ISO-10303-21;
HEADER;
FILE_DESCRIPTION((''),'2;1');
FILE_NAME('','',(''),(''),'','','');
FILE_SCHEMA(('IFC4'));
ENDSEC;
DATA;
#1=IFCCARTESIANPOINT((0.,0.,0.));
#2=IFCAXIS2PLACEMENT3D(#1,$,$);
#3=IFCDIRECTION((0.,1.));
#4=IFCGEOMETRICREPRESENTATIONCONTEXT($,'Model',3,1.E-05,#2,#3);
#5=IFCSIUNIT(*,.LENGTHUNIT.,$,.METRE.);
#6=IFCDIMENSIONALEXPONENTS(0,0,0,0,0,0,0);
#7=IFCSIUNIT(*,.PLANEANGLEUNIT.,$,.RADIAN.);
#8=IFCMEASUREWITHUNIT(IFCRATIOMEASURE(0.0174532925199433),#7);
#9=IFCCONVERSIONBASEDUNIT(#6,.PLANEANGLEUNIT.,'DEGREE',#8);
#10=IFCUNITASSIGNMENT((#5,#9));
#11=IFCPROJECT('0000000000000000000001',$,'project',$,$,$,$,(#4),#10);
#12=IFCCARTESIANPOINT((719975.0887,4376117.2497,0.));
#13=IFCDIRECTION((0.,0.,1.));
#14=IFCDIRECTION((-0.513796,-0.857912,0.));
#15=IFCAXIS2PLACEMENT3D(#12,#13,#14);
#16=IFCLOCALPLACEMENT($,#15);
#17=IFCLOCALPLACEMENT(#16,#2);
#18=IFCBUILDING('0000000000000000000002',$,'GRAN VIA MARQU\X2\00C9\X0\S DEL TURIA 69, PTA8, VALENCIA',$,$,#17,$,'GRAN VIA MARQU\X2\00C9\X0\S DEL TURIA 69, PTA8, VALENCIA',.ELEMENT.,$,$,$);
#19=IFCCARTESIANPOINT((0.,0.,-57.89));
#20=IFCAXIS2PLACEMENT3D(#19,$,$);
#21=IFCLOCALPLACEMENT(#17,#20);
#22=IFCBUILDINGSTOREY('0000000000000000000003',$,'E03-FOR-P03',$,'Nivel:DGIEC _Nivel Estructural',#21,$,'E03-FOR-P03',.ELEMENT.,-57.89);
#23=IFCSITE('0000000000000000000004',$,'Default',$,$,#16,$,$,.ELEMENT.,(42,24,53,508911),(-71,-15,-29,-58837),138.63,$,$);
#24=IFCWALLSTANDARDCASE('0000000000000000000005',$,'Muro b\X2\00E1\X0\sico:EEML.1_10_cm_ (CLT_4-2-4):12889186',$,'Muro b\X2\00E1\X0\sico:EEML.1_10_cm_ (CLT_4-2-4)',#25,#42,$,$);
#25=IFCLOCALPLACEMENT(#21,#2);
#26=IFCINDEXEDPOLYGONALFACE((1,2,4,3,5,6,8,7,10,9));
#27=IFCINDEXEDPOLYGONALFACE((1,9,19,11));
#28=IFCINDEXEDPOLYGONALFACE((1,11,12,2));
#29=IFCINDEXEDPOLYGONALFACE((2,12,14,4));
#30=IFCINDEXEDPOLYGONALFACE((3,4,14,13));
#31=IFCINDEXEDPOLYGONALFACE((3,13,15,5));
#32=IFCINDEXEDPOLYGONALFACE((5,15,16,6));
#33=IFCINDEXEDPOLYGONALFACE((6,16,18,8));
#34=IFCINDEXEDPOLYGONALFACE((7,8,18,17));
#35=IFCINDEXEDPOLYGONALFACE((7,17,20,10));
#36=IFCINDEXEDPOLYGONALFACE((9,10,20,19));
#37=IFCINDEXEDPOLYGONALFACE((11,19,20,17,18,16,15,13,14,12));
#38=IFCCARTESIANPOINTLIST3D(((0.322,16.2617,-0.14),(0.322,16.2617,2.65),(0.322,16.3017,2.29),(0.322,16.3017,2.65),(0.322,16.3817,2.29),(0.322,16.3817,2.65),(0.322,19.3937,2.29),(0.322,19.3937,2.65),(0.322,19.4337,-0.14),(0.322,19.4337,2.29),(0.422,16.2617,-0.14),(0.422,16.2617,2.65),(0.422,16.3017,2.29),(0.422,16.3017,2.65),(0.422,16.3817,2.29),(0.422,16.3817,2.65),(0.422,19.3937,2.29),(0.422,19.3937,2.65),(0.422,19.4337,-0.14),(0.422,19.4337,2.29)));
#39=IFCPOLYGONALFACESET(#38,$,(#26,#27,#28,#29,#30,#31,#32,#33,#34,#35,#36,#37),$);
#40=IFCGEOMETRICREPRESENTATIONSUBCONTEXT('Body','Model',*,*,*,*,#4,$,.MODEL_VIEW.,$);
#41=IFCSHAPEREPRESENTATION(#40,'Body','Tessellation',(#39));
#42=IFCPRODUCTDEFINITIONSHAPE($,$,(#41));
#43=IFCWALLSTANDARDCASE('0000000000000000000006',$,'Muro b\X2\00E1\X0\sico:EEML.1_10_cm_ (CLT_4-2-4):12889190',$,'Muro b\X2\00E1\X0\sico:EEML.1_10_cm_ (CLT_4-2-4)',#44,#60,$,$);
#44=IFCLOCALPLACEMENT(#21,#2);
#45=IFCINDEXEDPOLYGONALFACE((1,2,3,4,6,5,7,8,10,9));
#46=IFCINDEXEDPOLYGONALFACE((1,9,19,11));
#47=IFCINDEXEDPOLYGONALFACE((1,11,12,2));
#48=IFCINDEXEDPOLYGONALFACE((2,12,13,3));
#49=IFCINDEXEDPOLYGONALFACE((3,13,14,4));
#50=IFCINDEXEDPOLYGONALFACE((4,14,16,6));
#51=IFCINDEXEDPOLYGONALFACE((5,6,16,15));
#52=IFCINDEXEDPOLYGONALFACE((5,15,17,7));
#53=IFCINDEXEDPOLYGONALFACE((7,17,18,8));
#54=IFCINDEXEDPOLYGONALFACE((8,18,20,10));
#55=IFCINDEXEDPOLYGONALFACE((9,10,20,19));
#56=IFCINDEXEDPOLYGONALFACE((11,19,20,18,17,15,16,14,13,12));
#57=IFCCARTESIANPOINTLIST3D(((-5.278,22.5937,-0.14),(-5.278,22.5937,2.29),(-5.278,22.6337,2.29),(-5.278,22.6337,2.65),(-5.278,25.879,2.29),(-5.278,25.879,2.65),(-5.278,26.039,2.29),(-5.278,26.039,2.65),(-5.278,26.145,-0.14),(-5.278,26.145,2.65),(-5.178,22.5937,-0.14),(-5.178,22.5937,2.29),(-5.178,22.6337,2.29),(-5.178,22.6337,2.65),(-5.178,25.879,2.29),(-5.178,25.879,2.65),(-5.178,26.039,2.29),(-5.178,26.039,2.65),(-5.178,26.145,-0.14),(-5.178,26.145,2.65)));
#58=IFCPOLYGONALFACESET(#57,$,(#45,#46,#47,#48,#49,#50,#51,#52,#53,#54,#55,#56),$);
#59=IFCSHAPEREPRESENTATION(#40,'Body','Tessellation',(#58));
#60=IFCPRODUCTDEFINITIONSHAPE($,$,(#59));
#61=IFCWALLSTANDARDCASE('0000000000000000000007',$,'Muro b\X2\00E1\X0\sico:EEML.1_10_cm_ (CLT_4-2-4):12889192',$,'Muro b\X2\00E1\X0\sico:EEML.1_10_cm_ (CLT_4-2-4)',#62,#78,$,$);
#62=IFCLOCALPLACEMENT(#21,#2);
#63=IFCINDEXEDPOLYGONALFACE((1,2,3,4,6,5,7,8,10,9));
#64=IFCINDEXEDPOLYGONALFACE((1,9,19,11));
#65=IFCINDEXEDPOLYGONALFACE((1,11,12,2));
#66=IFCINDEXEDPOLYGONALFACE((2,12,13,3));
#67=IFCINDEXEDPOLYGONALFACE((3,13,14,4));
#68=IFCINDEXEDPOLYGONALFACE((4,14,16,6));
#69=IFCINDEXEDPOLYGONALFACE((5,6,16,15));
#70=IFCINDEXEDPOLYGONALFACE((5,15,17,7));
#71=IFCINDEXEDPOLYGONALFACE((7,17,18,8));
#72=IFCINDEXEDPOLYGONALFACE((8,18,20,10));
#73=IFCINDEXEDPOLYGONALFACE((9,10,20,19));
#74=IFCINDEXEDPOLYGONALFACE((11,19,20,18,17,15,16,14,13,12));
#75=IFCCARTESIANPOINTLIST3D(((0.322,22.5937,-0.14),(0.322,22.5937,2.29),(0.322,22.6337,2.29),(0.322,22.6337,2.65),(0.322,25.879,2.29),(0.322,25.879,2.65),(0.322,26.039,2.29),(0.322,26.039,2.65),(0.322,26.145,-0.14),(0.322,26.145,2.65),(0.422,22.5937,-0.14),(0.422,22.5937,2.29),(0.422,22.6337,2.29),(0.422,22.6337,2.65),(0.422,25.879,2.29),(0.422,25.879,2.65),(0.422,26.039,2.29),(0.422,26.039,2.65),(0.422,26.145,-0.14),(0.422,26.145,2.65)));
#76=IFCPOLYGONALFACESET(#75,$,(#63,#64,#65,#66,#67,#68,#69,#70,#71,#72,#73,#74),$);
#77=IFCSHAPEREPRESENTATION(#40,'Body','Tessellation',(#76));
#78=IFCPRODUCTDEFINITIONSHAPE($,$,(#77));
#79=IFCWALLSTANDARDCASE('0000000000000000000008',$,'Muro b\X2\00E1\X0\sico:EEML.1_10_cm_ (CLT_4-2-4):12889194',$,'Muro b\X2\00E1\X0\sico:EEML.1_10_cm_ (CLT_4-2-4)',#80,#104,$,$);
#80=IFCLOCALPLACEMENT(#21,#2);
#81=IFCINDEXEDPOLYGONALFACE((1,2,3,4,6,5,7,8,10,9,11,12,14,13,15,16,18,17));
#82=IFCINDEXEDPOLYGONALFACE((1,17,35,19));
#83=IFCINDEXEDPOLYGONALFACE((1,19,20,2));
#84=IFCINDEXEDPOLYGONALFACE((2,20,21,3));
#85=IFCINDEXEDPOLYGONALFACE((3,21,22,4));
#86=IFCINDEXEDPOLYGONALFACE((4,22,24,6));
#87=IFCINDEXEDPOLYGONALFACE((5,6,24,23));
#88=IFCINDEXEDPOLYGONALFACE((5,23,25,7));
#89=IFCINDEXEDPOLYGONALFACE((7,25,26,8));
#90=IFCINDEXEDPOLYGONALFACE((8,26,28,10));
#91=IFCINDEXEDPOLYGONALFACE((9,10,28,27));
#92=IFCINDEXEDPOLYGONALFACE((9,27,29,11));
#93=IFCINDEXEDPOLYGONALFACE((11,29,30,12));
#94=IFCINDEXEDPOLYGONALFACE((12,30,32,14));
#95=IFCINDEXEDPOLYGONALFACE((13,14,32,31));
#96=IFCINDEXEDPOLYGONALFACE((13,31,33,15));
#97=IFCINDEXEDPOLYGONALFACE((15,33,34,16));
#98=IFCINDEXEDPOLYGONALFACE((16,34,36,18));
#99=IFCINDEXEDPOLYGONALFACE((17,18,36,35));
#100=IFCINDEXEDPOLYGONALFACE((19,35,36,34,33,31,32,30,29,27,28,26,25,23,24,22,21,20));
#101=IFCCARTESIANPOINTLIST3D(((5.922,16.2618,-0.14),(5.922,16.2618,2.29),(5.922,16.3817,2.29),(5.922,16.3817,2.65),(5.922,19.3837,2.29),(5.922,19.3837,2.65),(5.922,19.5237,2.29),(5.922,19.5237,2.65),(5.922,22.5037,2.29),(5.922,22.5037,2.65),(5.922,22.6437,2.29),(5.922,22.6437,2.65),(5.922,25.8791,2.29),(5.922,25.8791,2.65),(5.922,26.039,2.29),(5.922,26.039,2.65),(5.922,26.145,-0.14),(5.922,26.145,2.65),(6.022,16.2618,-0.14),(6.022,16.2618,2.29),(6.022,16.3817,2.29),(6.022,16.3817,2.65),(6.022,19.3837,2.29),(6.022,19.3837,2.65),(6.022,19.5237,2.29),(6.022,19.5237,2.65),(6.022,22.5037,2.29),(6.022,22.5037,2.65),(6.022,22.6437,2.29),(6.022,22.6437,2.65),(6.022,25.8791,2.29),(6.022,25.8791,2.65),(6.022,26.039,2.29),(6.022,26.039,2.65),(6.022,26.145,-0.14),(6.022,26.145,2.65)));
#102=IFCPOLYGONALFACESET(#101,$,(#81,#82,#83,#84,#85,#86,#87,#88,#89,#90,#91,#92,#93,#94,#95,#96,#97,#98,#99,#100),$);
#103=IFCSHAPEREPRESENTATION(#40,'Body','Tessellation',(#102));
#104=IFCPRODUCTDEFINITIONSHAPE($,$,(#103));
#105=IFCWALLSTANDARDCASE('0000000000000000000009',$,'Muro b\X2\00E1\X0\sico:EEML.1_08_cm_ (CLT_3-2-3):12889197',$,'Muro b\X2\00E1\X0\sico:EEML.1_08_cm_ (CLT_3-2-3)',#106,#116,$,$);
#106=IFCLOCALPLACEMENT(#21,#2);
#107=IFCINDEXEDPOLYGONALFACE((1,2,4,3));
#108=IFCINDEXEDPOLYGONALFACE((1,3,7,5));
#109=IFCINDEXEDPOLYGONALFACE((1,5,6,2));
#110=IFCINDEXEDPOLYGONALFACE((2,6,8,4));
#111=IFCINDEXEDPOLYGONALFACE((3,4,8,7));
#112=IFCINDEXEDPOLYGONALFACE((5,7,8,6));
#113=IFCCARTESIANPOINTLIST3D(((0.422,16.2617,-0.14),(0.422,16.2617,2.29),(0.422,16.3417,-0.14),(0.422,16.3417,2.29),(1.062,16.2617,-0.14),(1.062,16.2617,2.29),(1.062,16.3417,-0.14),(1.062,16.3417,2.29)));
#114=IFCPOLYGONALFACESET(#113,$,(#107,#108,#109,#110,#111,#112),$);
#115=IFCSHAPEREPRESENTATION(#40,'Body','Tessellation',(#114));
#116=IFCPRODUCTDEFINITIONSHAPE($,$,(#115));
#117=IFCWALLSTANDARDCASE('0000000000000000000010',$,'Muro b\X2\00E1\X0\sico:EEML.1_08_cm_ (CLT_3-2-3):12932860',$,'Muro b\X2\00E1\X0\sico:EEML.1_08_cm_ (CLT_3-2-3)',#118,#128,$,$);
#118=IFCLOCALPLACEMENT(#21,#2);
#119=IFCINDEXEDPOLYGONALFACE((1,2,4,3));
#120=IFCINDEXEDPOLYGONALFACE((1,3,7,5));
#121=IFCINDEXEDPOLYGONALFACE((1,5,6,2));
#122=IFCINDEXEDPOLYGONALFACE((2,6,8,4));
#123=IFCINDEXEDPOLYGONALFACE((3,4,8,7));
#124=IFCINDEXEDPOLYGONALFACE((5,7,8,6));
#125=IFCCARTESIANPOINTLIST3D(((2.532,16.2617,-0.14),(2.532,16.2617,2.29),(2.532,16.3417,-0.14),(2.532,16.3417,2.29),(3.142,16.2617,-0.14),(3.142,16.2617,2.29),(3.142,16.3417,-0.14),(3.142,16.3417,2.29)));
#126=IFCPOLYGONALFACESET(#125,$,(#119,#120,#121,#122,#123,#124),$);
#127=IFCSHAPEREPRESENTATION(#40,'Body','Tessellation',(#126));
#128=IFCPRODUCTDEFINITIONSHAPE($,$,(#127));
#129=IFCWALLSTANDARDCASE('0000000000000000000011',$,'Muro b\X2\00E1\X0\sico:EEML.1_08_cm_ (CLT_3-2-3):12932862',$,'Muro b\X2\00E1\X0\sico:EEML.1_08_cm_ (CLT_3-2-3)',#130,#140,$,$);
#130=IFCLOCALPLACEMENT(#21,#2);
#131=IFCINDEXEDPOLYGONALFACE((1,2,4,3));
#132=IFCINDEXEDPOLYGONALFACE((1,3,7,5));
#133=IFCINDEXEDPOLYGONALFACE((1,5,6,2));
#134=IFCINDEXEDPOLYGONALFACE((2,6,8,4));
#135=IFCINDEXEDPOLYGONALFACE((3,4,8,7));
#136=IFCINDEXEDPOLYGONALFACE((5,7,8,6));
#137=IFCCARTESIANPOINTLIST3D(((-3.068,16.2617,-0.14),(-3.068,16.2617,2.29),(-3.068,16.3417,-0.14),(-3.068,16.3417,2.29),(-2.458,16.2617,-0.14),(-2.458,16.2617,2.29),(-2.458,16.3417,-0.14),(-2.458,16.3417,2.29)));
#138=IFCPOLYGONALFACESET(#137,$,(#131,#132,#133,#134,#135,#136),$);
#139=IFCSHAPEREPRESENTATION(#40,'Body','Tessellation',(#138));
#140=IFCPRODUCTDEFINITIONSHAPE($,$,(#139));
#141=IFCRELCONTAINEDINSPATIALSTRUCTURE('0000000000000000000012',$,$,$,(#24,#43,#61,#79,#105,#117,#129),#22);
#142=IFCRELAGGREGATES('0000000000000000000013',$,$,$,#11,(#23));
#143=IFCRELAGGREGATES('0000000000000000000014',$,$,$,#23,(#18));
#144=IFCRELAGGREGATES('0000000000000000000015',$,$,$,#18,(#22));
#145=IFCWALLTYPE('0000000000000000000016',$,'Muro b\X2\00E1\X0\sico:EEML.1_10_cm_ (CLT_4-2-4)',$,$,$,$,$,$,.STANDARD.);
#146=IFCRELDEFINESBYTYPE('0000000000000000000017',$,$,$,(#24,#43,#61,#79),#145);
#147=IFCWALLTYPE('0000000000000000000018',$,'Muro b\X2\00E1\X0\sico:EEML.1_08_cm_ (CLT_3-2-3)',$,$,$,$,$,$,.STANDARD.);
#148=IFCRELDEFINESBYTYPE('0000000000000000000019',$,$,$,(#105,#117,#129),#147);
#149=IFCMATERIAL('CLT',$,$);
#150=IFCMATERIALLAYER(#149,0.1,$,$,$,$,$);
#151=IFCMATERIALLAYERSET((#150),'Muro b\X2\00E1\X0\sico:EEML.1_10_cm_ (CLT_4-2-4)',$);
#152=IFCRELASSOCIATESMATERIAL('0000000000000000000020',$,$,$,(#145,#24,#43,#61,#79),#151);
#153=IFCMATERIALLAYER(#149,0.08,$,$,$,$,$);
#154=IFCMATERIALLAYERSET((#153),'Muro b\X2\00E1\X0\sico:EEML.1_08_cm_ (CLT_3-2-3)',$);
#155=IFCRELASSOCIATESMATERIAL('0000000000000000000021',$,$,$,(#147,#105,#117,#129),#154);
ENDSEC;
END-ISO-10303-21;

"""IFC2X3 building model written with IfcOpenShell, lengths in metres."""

from ifc_helpers import new_model, entity, si_unit, converted_unit, direction, frame, frame_2d, origin, place, context, subcontext, project, spatial, rectangle, extrude, material, layer, layer_set, layer_usage, type_object, element, save


model = new_model("IFC2X3")

# Units and contexts
model_context = context("Model", 3, precision=1e-05, world=origin(), true_north=direction((0.0, 1.0)))
body_context = subcontext(model_context, "Body", "Model", "MODEL_VIEW")
ifc_project = project(units=[si_unit("LENGTHUNIT", "METRE"), converted_unit("PLANEANGLEUNIT", "DEGREE", entity("IfcRatioMeasure", 0.0174532925199433), si_unit("PLANEANGLEUNIT", "RADIAN"), dimensions=[0, 0, 0, 0, 0, 0, 0])], contexts=[model_context])

# Site, building, storey
site_placement = place(None, frame((719975.0887, 4376117.2497, 0.0), z_axis=(0.0, 0.0, 1.0), x_axis=(-0.513796, -0.857912, 0.0)))
site = spatial("IfcSite", under=ifc_project, at=site_placement, Name="Default", CompositionType="ELEMENT", RefLatitude=(42, 24, 53, 508911), RefLongitude=(-71, -15, -29, -58837), RefElevation=138.63)
building_placement = place(site_placement, origin())
building = spatial("IfcBuilding", under=site, at=building_placement, Name="GRAN VIA MARQUÉS DEL TURIA 69, PTA8, VALENCIA", LongName="GRAN VIA MARQUÉS DEL TURIA 69, PTA8, VALENCIA", CompositionType="ELEMENT")
storey_placement = place(building_placement, frame((0.0, 0.0, -57.89)))
storey = spatial("IfcBuildingStorey", under=building, at=storey_placement, Name="E03-FOR-P03", ObjectType="Nivel:DGIEC _Nivel Estructural", LongName="E03-FOR-P03", CompositionType="ELEMENT", Elevation=-57.89)

# Shared definitions
ifc_material = material(Name="CLT")

# Walls, openings
ifc_layer_1 = layer(ifc_material, 0.1)
ifc_layer_set_1 = layer_set([ifc_layer_1], Name="Muro básico:EEML.1_10_cm_ (CLT_4-2-4)")
ifc_layer_usage_1 = layer_usage(ifc_layer_set_1, "AXIS2", "NEGATIVE", 0.05)
wall_type_1 = type_object("IfcWallType", Name="Muro básico:EEML.1_10_cm_ (CLT_4-2-4)", PredefinedType="STANDARD", material=ifc_layer_set_1)
wall_1_placement = place(storey_placement, frame((0.372, 16.2617, -0.14), z_axis=(0.0, 0.0, 1.0), x_axis=(0.0, 1.0, 0.0)))
wall_1 = element("IfcWallStandardCase", 1, at=wall_1_placement, inside=storey, type_object=wall_type_1, material=ifc_layer_usage_1, Name="Muro básico:EEML.1_10_cm_ (CLT_4-2-4):12889186", ObjectType="Muro básico:EEML.1_10_cm_ (CLT_4-2-4)", context=body_context, shape_type="SweptSolid", body=[
    extrude(rectangle(XDim=3.172, YDim=0.1, at=frame_2d((1.586, 0.0), x_axis=(-1.0, 0.0))), origin(), (0.0, 0.0, 1.0), 2.79),
])
opening_1_placement = place(wall_1_placement, origin())
element("IfcOpeningElement", 2, at=opening_1_placement, cuts=wall_1, ObjectType="Opening", context=body_context, shape_type="SweptSolid", body=[
    extrude(rectangle(XDim=0.36, YDim=0.08, at=frame_2d((0.0, 0.0), x_axis=(1.0, 0.0))), frame((3.172, 0.05, 2.61), z_axis=(0.0, -1.0, 0.0), x_axis=(0.0, 0.0, 1.0)), (0.0, 0.0, 1.0), 0.1),
])
opening_2_placement = place(wall_1_placement, origin())
element("IfcOpeningElement", 3, at=opening_2_placement, cuts=wall_1, ObjectType="Opening", context=body_context, shape_type="SweptSolid", body=[
    extrude(rectangle(XDim=0.36, YDim=0.08, at=frame_2d((0.0, 0.0), x_axis=(0.0, 1.0))), frame((0.08, 0.05, 2.61), z_axis=(0.0, -1.0, 0.0), x_axis=(-1.0, 0.0, 0.0)), (0.0, 0.0, 1.0), 0.1),
])
ifc_layer_usage_2 = layer_usage(ifc_layer_set_1, "AXIS2", "NEGATIVE", 0.05)
wall_2_placement = place(storey_placement, frame((-5.228, 22.5937, -0.14), z_axis=(0.0, 0.0, 1.0), x_axis=(0.0, 1.0, 0.0)))
wall_2 = element("IfcWallStandardCase", 4, at=wall_2_placement, inside=storey, type_object=wall_type_1, material=ifc_layer_usage_2, Name="Muro básico:EEML.1_10_cm_ (CLT_4-2-4):12889190", ObjectType="Muro básico:EEML.1_10_cm_ (CLT_4-2-4)", context=body_context, shape_type="SweptSolid", body=[
    extrude(rectangle(XDim=3.5513, YDim=0.1, at=frame_2d((1.7757, 0.0), x_axis=(-1.0, 0.0))), origin(), (0.0, 0.0, 1.0), 2.79),
])
opening_3_placement = place(wall_2_placement, origin())
element("IfcOpeningElement", 5, at=opening_3_placement, cuts=wall_2, ObjectType="Opening", context=body_context, shape_type="SweptSolid", body=[
    extrude(rectangle(XDim=0.36, YDim=0.16, at=frame_2d((0.0, 0.0), x_axis=(0.0, 1.0))), frame((3.3653, 0.05, 2.61), z_axis=(0.0, -1.0, 0.0), x_axis=(-1.0, 0.0, 0.0)), (0.0, 0.0, 1.0), 0.1),
])
opening_4_placement = place(wall_2_placement, origin())
element("IfcOpeningElement", 6, at=opening_4_placement, cuts=wall_2, ObjectType="Opening", context=body_context, shape_type="SweptSolid", body=[
    extrude(rectangle(XDim=0.36, YDim=0.08, at=frame_2d((0.0, 0.0), x_axis=(0.0, 1.0))), frame((0.0, 0.05, 2.61), z_axis=(0.0, -1.0, 0.0), x_axis=(-1.0, 0.0, 0.0)), (0.0, 0.0, 1.0), 0.1),
])
ifc_layer_usage_3 = layer_usage(ifc_layer_set_1, "AXIS2", "NEGATIVE", 0.05)
wall_3_placement = place(storey_placement, frame((0.372, 22.5937, -0.14), z_axis=(0.0, 0.0, 1.0), x_axis=(0.0, 1.0, 0.0)))
wall_3 = element("IfcWallStandardCase", 7, at=wall_3_placement, inside=storey, type_object=wall_type_1, material=ifc_layer_usage_3, Name="Muro básico:EEML.1_10_cm_ (CLT_4-2-4):12889192", ObjectType="Muro básico:EEML.1_10_cm_ (CLT_4-2-4)", context=body_context, shape_type="SweptSolid", body=[
    extrude(rectangle(XDim=3.5513, YDim=0.1, at=frame_2d((1.7757, 0.0), x_axis=(-1.0, 0.0))), origin(), (0.0, 0.0, 1.0), 2.79),
])
opening_5_placement = place(wall_3_placement, origin())
element("IfcOpeningElement", 8, at=opening_5_placement, cuts=wall_3, ObjectType="Opening", context=body_context, shape_type="SweptSolid", body=[
    extrude(rectangle(XDim=0.36, YDim=0.16, at=frame_2d((0.0, 0.0), x_axis=(0.0, 1.0))), frame((3.3653, 0.05, 2.61), z_axis=(0.0, -1.0, 0.0), x_axis=(-1.0, 0.0, 0.0)), (0.0, 0.0, 1.0), 0.1),
])
opening_6_placement = place(wall_3_placement, origin())
element("IfcOpeningElement", 9, at=opening_6_placement, cuts=wall_3, ObjectType="Opening", context=body_context, shape_type="SweptSolid", body=[
    extrude(rectangle(XDim=0.36, YDim=0.08, at=frame_2d((0.0, 0.0), x_axis=(0.0, 1.0))), frame((0.0, 0.05, 2.61), z_axis=(0.0, -1.0, 0.0), x_axis=(-1.0, 0.0, 0.0)), (0.0, 0.0, 1.0), 0.1),
])
ifc_layer_usage_4 = layer_usage(ifc_layer_set_1, "AXIS2", "NEGATIVE", 0.05)
wall_4_placement = place(storey_placement, frame((5.972, 16.2618, -0.14), z_axis=(0.0, 0.0, 1.0), x_axis=(0.0, 1.0, 0.0)))
wall_4 = element("IfcWallStandardCase", 10, at=wall_4_placement, inside=storey, type_object=wall_type_1, material=ifc_layer_usage_4, Name="Muro básico:EEML.1_10_cm_ (CLT_4-2-4):12889194", ObjectType="Muro básico:EEML.1_10_cm_ (CLT_4-2-4)", context=body_context, shape_type="SweptSolid", body=[
    extrude(rectangle(XDim=9.8833, YDim=0.1, at=frame_2d((4.9416, 0.0), x_axis=(-1.0, 0.0))), origin(), (0.0, 0.0, 1.0), 2.79),
])
opening_7_placement = place(wall_4_placement, origin())
element("IfcOpeningElement", 11, at=opening_7_placement, cuts=wall_4, ObjectType="Opening", context=body_context, shape_type="SweptSolid", body=[
    extrude(rectangle(XDim=0.36, YDim=0.1599, at=frame_2d((0.0, 0.0), x_axis=(0.0, 1.0))), frame((9.6973, 0.05, 2.61), z_axis=(0.0, -1.0, 0.0), x_axis=(-1.0, 0.0, 0.0)), (0.0, 0.0, 1.0), 0.1),
])
opening_8_placement = place(wall_4_placement, origin())
element("IfcOpeningElement", 12, at=opening_8_placement, cuts=wall_4, ObjectType="Opening", context=body_context, shape_type="SweptSolid", body=[
    extrude(rectangle(XDim=0.36, YDim=0.14, at=frame_2d((0.0, 0.0), x_axis=(0.0, 1.0))), frame((6.312, 0.05, 2.61), z_axis=(0.0, -1.0, 0.0), x_axis=(-1.0, 0.0, 0.0)), (0.0, 0.0, 1.0), 0.1),
])
opening_9_placement = place(wall_4_placement, origin())
element("IfcOpeningElement", 13, at=opening_9_placement, cuts=wall_4, ObjectType="Opening", context=body_context, shape_type="SweptSolid", body=[
    extrude(rectangle(XDim=0.36, YDim=0.14, at=frame_2d((0.0, 0.0), x_axis=(0.0, 1.0))), frame((3.192, 0.05, 2.61), z_axis=(0.0, -1.0, 0.0), x_axis=(-1.0, 0.0, 0.0)), (0.0, 0.0, 1.0), 0.1),
])
opening_10_placement = place(wall_4_placement, origin())
element("IfcOpeningElement", 14, at=opening_10_placement, cuts=wall_4, ObjectType="Opening", context=body_context, shape_type="SweptSolid", body=[
    extrude(rectangle(XDim=0.36, YDim=0.12, at=frame_2d((0.0, 0.0), x_axis=(0.0, 1.0))), frame((0.06, 0.05, 2.61), z_axis=(0.0, -1.0, 0.0), x_axis=(-1.0, 0.0, 0.0)), (0.0, 0.0, 1.0), 0.1),
])

# Walls
ifc_layer_2 = layer(ifc_material, 0.08)
ifc_layer_set_2 = layer_set([ifc_layer_2], Name="Muro básico:EEML.1_08_cm_ (CLT_3-2-3)")
ifc_layer_usage_5 = layer_usage(ifc_layer_set_2, "AXIS2", "NEGATIVE", 0.04)
wall_type_2 = type_object("IfcWallType", Name="Muro básico:EEML.1_08_cm_ (CLT_3-2-3)", PredefinedType="STANDARD", material=ifc_layer_set_2)
wall_5_placement = place(storey_placement, frame((1.062, 16.3017, -0.14), z_axis=(0.0, 0.0, 1.0), x_axis=(-1.0, 0.0, 0.0)))
element("IfcWallStandardCase", 15, at=wall_5_placement, inside=storey, type_object=wall_type_2, material=ifc_layer_usage_5, Name="Muro básico:EEML.1_08_cm_ (CLT_3-2-3):12889197", ObjectType="Muro básico:EEML.1_08_cm_ (CLT_3-2-3)", context=body_context, shape_type="SweptSolid", body=[
    extrude(rectangle(XDim=0.64, YDim=0.08, at=frame_2d((0.32, 0.0), x_axis=(-1.0, 0.0))), origin(), (0.0, 0.0, 1.0), 2.43),
])
ifc_layer_usage_6 = layer_usage(ifc_layer_set_2, "AXIS2", "NEGATIVE", 0.04)
wall_6_placement = place(storey_placement, frame((3.142, 16.3017, -0.14), z_axis=(0.0, 0.0, 1.0), x_axis=(-1.0, 0.0, 0.0)))
element("IfcWallStandardCase", 16, at=wall_6_placement, inside=storey, type_object=wall_type_2, material=ifc_layer_usage_6, Name="Muro básico:EEML.1_08_cm_ (CLT_3-2-3):12932860", ObjectType="Muro básico:EEML.1_08_cm_ (CLT_3-2-3)", context=body_context, shape_type="SweptSolid", body=[
    extrude(rectangle(XDim=0.61, YDim=0.08, at=frame_2d((0.305, 0.0), x_axis=(-1.0, 0.0))), origin(), (0.0, 0.0, 1.0), 2.43),
])
ifc_layer_usage_7 = layer_usage(ifc_layer_set_2, "AXIS2", "NEGATIVE", 0.04)
wall_7_placement = place(storey_placement, frame((-2.458, 16.3017, -0.14), z_axis=(0.0, 0.0, 1.0), x_axis=(-1.0, 0.0, 0.0)))
element("IfcWallStandardCase", 17, at=wall_7_placement, inside=storey, type_object=wall_type_2, material=ifc_layer_usage_7, Name="Muro básico:EEML.1_08_cm_ (CLT_3-2-3):12932862", ObjectType="Muro básico:EEML.1_08_cm_ (CLT_3-2-3)", context=body_context, shape_type="SweptSolid", body=[
    extrude(rectangle(XDim=0.61, YDim=0.08, at=frame_2d((0.305, 0.0), x_axis=(-1.0, 0.0))), origin(), (0.0, 0.0, 1.0), 2.43),
])

save(model, "model.ifc")
